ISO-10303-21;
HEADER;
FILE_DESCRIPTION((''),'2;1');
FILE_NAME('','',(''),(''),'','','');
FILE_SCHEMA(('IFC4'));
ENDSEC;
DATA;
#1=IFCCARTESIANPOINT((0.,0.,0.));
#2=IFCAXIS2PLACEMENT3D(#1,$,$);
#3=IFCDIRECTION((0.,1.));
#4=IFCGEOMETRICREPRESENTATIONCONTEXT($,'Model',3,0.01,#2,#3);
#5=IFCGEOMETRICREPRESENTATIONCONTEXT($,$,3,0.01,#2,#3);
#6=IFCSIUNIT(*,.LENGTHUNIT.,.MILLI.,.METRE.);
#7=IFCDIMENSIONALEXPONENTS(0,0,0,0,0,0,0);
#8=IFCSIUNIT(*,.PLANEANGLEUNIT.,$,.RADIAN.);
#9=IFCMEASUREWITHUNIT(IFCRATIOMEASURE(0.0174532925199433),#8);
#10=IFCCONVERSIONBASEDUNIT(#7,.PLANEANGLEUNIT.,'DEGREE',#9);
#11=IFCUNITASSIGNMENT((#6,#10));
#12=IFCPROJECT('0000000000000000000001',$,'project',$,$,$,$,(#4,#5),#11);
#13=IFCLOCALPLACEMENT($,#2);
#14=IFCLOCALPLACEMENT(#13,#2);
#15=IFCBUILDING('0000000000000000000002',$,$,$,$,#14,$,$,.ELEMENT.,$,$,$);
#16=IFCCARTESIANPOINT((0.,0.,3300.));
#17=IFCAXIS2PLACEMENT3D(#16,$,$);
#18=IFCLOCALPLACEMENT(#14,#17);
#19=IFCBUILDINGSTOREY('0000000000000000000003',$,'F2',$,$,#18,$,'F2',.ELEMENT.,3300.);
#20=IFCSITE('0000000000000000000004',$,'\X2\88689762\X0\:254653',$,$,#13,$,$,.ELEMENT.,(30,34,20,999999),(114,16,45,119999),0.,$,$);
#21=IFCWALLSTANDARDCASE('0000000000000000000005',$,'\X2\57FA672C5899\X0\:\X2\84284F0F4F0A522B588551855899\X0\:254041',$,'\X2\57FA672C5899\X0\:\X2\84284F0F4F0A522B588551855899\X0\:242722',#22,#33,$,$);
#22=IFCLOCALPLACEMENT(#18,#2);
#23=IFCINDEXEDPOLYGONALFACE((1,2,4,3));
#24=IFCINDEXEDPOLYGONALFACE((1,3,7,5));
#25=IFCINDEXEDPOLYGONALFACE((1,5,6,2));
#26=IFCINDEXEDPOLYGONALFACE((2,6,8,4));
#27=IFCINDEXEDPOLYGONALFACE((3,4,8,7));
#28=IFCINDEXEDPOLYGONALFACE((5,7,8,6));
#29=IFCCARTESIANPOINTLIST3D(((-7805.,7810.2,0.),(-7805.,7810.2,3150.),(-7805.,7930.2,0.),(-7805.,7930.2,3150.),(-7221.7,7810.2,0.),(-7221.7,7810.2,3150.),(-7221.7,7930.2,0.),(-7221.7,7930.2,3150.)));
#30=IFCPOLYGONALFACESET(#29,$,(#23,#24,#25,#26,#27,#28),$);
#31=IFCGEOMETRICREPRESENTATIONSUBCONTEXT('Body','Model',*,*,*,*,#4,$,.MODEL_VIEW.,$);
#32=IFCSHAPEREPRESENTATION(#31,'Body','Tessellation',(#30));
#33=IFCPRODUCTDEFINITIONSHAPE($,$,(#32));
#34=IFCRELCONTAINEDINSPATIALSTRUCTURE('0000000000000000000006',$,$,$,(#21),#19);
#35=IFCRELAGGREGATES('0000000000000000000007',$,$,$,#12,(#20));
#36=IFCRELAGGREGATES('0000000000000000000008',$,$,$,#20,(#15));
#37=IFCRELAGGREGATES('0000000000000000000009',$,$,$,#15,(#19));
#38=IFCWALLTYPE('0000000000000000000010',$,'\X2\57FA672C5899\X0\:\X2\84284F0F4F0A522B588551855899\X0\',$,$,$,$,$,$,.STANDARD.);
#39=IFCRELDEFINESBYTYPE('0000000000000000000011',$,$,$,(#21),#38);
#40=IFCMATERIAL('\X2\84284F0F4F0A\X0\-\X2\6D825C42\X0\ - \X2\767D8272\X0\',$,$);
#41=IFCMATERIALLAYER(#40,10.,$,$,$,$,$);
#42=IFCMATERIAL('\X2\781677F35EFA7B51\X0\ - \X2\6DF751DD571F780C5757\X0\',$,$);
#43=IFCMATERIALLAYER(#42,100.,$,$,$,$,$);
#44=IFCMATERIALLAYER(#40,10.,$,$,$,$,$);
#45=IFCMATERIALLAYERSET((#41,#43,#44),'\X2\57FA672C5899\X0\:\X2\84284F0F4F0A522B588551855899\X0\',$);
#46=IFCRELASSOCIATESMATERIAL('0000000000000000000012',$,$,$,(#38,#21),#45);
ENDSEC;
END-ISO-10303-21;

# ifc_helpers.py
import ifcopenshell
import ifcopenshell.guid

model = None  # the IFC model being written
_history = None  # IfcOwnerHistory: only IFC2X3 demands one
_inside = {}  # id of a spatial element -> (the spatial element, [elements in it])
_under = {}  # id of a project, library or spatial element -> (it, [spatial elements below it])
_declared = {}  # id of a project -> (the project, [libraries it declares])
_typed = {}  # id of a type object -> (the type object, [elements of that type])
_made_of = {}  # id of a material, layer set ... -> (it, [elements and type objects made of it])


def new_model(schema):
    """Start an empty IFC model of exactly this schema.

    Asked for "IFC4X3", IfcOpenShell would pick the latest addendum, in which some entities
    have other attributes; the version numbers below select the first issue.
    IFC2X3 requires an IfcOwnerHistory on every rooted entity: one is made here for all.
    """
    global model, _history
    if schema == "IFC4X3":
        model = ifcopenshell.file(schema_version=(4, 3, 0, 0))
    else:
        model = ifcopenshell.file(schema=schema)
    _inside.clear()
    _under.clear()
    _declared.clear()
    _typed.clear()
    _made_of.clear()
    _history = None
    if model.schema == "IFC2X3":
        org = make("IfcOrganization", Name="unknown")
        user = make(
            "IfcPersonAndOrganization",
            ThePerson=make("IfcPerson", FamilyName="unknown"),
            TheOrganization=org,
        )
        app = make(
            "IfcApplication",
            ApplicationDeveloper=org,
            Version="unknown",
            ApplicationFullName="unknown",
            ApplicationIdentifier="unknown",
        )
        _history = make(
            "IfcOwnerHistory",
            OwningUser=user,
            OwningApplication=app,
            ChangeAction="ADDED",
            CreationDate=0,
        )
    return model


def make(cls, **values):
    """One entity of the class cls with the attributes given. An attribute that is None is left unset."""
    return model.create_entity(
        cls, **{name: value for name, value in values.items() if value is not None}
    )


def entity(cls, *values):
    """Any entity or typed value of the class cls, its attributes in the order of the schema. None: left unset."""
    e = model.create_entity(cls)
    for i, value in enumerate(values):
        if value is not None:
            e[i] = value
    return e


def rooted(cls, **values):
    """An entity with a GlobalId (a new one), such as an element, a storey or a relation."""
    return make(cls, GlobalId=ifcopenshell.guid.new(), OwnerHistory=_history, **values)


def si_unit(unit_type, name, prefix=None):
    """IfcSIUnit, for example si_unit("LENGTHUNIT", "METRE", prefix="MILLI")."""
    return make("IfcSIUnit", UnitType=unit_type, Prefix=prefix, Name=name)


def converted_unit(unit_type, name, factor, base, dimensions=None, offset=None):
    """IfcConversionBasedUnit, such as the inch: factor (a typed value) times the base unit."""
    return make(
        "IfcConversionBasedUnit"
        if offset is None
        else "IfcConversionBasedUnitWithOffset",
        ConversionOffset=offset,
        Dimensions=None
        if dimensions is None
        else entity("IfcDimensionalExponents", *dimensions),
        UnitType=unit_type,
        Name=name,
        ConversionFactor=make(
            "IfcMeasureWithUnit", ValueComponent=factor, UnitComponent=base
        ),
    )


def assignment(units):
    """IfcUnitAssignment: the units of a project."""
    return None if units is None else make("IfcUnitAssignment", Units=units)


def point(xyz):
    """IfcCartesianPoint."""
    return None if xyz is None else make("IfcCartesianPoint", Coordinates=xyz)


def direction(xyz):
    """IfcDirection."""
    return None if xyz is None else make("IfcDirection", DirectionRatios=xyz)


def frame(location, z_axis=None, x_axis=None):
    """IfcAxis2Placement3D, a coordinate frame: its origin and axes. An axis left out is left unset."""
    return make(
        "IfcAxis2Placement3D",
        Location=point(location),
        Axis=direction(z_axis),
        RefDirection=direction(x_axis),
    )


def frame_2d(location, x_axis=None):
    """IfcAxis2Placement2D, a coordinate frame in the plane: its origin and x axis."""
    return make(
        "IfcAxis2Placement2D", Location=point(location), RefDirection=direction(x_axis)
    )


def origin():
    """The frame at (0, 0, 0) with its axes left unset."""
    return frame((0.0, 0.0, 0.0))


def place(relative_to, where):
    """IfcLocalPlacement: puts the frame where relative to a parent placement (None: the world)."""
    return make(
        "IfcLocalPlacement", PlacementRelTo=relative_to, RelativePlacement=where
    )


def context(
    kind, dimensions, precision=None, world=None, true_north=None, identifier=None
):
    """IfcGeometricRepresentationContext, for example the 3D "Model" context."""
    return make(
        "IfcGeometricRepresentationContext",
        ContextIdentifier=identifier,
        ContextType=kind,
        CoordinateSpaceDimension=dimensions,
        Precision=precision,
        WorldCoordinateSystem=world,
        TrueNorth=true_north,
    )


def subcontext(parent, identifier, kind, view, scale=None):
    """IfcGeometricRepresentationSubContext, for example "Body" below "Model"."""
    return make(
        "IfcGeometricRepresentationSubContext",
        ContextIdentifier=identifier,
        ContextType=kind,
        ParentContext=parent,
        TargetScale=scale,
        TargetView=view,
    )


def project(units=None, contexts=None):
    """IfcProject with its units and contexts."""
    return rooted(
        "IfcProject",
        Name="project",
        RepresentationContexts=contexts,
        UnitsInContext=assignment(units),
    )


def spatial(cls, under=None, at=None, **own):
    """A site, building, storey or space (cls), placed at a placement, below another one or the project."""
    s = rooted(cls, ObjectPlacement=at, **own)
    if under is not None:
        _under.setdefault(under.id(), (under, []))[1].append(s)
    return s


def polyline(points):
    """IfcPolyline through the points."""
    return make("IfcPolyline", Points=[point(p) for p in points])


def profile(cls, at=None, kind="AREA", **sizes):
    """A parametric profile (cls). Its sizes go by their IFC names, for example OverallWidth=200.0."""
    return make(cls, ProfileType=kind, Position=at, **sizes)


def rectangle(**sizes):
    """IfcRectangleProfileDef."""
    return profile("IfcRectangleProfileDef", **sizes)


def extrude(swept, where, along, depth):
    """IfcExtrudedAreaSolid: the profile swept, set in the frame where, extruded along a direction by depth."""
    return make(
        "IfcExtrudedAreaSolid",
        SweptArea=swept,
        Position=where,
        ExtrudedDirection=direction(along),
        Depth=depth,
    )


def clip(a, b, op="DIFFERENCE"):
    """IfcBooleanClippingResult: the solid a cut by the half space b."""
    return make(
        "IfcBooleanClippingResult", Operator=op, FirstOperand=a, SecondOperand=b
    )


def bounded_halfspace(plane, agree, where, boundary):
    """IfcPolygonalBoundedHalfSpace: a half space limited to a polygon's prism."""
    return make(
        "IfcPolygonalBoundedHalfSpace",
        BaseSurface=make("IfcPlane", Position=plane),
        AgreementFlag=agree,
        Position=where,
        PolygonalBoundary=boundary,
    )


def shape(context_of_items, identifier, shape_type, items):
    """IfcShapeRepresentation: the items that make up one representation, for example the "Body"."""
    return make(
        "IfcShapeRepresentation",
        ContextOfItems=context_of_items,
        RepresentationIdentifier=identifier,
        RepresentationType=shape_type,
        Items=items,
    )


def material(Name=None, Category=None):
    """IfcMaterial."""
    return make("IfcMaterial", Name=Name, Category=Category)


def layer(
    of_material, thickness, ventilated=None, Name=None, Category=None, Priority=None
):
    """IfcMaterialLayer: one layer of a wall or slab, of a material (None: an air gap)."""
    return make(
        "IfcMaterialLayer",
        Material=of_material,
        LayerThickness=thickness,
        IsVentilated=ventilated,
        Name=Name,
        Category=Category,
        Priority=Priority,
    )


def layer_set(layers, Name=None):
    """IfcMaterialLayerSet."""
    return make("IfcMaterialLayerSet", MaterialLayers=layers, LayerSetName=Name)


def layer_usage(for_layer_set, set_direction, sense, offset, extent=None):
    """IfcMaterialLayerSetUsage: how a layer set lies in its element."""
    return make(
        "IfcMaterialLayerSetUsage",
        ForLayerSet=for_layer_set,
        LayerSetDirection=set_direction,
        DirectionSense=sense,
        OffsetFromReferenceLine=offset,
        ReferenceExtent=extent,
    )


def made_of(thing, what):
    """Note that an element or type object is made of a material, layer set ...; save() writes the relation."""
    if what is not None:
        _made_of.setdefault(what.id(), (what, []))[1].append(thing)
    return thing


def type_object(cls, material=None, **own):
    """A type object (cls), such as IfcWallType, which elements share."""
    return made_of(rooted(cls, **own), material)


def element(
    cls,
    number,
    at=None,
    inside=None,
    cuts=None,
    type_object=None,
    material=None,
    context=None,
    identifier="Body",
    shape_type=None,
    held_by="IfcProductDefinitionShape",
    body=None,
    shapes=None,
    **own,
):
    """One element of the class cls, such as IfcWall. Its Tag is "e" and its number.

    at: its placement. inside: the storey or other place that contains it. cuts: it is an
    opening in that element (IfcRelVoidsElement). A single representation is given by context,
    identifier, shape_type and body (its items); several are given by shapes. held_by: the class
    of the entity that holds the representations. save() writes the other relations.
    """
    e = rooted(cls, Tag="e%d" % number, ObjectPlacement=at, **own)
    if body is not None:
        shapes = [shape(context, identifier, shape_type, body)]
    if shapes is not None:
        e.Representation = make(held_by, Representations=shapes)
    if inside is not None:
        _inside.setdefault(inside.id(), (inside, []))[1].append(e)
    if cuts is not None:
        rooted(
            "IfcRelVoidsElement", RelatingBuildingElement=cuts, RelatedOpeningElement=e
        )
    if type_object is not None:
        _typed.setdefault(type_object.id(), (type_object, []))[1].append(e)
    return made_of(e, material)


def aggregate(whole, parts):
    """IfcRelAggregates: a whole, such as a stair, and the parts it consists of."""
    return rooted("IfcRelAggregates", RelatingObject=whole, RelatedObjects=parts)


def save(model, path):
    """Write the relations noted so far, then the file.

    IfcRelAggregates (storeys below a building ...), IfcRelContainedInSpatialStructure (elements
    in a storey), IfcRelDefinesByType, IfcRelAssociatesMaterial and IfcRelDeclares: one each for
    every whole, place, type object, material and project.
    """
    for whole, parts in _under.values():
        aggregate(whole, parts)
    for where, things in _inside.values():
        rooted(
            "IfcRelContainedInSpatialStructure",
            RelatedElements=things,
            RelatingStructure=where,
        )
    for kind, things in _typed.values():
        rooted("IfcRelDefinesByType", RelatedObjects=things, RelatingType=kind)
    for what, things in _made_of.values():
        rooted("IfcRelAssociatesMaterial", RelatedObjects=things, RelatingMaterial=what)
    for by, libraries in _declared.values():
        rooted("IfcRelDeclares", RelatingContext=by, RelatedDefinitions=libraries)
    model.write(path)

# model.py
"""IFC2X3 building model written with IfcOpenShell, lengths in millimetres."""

from ifc_helpers import new_model, entity, si_unit, converted_unit, direction, frame, frame_2d, origin, place, context, subcontext, project, spatial, polyline, rectangle, extrude, clip, bounded_halfspace, material, layer, layer_set, layer_usage, type_object, element, save


model = new_model("IFC2X3")

# Units and contexts
model_context = context("Model", 3, precision=0.01, world=origin(), true_north=direction((0.0, 1.0)))
context_of_model = context(None, 3, precision=0.01, world=origin(), true_north=direction((0.0, 1.0)))
body_context = subcontext(model_context, "Body", "Model", "MODEL_VIEW")
ifc_project = project(units=[si_unit("LENGTHUNIT", "METRE", prefix="MILLI"), converted_unit("PLANEANGLEUNIT", "DEGREE", entity("IfcRatioMeasure", 0.0174532925199433), si_unit("PLANEANGLEUNIT", "RADIAN"), dimensions=[0, 0, 0, 0, 0, 0, 0])], contexts=[model_context, context_of_model])

# Site, building, storey
site_placement = place(None, origin())
site = spatial("IfcSite", under=ifc_project, at=site_placement, Name="表面:254653", CompositionType="ELEMENT", RefLatitude=(30, 34, 20, 999999), RefLongitude=(114, 16, 45, 119999), RefElevation=0.0)
building_placement = place(site_placement, origin())
building = spatial("IfcBuilding", under=site, at=building_placement, CompositionType="ELEMENT")
storey_placement = place(building_placement, frame((0.0, 0.0, 3300.0)))
storey = spatial("IfcBuildingStorey", under=building, at=storey_placement, Name="F2", LongName="F2", CompositionType="ELEMENT", Elevation=3300.0)

# Shared definitions
ifc_material_1 = material(Name="萨伏伊-涂层 - 白色")
ifc_layer_1 = layer(ifc_material_1, 10.0)
ifc_material_2 = material(Name="砖石建筑 - 混凝土砌块")
ifc_layer_2 = layer(ifc_material_2, 100.0)
ifc_layer_3 = layer(ifc_material_1, 10.0)
ifc_layer_set_1 = layer_set([ifc_layer_1, ifc_layer_2, ifc_layer_3], Name="基本墙:萨伏伊别墅内墙")
wall_type_1 = type_object("IfcWallType", Name="基本墙:萨伏伊别墅内墙", PredefinedType="STANDARD", material=ifc_layer_set_1)

# Wall
ifc_layer_usage_1 = layer_usage(ifc_layer_set_1, "AXIS2", "NEGATIVE", 60.0)
wall_1_placement = place(storey_placement, frame((-7805.0, 7870.2, 0.0)))
element("IfcWallStandardCase", 1, at=wall_1_placement, inside=storey, type_object=wall_type_1, material=ifc_layer_usage_1, Name="基本墙:萨伏伊别墅内墙:254041", ObjectType="基本墙:萨伏伊别墅内墙:242722", context=body_context, shape_type="Clipping", body=[
    clip(extrude(rectangle(XDim=583.3, YDim=120.0, at=frame_2d((291.7, 0.0), x_axis=(-1.0, 0.0))), origin(), (0.0, 0.0, 1.0), 3150.0), bounded_halfspace(frame((0.0, -60.0, 3150.0), z_axis=(0.0, 0.0, -1.0), x_axis=(0.0, -1.0, 0.0)), True, frame((0.0, -60.0, 3150.0)), polyline([(0.0, 0.0), (583.3, 0.0), (583.3, 120.0), (463.3, 120.0), (0.0, 120.0), (0.0, 0.0)]))),
])

save(model, "model.ifc")
